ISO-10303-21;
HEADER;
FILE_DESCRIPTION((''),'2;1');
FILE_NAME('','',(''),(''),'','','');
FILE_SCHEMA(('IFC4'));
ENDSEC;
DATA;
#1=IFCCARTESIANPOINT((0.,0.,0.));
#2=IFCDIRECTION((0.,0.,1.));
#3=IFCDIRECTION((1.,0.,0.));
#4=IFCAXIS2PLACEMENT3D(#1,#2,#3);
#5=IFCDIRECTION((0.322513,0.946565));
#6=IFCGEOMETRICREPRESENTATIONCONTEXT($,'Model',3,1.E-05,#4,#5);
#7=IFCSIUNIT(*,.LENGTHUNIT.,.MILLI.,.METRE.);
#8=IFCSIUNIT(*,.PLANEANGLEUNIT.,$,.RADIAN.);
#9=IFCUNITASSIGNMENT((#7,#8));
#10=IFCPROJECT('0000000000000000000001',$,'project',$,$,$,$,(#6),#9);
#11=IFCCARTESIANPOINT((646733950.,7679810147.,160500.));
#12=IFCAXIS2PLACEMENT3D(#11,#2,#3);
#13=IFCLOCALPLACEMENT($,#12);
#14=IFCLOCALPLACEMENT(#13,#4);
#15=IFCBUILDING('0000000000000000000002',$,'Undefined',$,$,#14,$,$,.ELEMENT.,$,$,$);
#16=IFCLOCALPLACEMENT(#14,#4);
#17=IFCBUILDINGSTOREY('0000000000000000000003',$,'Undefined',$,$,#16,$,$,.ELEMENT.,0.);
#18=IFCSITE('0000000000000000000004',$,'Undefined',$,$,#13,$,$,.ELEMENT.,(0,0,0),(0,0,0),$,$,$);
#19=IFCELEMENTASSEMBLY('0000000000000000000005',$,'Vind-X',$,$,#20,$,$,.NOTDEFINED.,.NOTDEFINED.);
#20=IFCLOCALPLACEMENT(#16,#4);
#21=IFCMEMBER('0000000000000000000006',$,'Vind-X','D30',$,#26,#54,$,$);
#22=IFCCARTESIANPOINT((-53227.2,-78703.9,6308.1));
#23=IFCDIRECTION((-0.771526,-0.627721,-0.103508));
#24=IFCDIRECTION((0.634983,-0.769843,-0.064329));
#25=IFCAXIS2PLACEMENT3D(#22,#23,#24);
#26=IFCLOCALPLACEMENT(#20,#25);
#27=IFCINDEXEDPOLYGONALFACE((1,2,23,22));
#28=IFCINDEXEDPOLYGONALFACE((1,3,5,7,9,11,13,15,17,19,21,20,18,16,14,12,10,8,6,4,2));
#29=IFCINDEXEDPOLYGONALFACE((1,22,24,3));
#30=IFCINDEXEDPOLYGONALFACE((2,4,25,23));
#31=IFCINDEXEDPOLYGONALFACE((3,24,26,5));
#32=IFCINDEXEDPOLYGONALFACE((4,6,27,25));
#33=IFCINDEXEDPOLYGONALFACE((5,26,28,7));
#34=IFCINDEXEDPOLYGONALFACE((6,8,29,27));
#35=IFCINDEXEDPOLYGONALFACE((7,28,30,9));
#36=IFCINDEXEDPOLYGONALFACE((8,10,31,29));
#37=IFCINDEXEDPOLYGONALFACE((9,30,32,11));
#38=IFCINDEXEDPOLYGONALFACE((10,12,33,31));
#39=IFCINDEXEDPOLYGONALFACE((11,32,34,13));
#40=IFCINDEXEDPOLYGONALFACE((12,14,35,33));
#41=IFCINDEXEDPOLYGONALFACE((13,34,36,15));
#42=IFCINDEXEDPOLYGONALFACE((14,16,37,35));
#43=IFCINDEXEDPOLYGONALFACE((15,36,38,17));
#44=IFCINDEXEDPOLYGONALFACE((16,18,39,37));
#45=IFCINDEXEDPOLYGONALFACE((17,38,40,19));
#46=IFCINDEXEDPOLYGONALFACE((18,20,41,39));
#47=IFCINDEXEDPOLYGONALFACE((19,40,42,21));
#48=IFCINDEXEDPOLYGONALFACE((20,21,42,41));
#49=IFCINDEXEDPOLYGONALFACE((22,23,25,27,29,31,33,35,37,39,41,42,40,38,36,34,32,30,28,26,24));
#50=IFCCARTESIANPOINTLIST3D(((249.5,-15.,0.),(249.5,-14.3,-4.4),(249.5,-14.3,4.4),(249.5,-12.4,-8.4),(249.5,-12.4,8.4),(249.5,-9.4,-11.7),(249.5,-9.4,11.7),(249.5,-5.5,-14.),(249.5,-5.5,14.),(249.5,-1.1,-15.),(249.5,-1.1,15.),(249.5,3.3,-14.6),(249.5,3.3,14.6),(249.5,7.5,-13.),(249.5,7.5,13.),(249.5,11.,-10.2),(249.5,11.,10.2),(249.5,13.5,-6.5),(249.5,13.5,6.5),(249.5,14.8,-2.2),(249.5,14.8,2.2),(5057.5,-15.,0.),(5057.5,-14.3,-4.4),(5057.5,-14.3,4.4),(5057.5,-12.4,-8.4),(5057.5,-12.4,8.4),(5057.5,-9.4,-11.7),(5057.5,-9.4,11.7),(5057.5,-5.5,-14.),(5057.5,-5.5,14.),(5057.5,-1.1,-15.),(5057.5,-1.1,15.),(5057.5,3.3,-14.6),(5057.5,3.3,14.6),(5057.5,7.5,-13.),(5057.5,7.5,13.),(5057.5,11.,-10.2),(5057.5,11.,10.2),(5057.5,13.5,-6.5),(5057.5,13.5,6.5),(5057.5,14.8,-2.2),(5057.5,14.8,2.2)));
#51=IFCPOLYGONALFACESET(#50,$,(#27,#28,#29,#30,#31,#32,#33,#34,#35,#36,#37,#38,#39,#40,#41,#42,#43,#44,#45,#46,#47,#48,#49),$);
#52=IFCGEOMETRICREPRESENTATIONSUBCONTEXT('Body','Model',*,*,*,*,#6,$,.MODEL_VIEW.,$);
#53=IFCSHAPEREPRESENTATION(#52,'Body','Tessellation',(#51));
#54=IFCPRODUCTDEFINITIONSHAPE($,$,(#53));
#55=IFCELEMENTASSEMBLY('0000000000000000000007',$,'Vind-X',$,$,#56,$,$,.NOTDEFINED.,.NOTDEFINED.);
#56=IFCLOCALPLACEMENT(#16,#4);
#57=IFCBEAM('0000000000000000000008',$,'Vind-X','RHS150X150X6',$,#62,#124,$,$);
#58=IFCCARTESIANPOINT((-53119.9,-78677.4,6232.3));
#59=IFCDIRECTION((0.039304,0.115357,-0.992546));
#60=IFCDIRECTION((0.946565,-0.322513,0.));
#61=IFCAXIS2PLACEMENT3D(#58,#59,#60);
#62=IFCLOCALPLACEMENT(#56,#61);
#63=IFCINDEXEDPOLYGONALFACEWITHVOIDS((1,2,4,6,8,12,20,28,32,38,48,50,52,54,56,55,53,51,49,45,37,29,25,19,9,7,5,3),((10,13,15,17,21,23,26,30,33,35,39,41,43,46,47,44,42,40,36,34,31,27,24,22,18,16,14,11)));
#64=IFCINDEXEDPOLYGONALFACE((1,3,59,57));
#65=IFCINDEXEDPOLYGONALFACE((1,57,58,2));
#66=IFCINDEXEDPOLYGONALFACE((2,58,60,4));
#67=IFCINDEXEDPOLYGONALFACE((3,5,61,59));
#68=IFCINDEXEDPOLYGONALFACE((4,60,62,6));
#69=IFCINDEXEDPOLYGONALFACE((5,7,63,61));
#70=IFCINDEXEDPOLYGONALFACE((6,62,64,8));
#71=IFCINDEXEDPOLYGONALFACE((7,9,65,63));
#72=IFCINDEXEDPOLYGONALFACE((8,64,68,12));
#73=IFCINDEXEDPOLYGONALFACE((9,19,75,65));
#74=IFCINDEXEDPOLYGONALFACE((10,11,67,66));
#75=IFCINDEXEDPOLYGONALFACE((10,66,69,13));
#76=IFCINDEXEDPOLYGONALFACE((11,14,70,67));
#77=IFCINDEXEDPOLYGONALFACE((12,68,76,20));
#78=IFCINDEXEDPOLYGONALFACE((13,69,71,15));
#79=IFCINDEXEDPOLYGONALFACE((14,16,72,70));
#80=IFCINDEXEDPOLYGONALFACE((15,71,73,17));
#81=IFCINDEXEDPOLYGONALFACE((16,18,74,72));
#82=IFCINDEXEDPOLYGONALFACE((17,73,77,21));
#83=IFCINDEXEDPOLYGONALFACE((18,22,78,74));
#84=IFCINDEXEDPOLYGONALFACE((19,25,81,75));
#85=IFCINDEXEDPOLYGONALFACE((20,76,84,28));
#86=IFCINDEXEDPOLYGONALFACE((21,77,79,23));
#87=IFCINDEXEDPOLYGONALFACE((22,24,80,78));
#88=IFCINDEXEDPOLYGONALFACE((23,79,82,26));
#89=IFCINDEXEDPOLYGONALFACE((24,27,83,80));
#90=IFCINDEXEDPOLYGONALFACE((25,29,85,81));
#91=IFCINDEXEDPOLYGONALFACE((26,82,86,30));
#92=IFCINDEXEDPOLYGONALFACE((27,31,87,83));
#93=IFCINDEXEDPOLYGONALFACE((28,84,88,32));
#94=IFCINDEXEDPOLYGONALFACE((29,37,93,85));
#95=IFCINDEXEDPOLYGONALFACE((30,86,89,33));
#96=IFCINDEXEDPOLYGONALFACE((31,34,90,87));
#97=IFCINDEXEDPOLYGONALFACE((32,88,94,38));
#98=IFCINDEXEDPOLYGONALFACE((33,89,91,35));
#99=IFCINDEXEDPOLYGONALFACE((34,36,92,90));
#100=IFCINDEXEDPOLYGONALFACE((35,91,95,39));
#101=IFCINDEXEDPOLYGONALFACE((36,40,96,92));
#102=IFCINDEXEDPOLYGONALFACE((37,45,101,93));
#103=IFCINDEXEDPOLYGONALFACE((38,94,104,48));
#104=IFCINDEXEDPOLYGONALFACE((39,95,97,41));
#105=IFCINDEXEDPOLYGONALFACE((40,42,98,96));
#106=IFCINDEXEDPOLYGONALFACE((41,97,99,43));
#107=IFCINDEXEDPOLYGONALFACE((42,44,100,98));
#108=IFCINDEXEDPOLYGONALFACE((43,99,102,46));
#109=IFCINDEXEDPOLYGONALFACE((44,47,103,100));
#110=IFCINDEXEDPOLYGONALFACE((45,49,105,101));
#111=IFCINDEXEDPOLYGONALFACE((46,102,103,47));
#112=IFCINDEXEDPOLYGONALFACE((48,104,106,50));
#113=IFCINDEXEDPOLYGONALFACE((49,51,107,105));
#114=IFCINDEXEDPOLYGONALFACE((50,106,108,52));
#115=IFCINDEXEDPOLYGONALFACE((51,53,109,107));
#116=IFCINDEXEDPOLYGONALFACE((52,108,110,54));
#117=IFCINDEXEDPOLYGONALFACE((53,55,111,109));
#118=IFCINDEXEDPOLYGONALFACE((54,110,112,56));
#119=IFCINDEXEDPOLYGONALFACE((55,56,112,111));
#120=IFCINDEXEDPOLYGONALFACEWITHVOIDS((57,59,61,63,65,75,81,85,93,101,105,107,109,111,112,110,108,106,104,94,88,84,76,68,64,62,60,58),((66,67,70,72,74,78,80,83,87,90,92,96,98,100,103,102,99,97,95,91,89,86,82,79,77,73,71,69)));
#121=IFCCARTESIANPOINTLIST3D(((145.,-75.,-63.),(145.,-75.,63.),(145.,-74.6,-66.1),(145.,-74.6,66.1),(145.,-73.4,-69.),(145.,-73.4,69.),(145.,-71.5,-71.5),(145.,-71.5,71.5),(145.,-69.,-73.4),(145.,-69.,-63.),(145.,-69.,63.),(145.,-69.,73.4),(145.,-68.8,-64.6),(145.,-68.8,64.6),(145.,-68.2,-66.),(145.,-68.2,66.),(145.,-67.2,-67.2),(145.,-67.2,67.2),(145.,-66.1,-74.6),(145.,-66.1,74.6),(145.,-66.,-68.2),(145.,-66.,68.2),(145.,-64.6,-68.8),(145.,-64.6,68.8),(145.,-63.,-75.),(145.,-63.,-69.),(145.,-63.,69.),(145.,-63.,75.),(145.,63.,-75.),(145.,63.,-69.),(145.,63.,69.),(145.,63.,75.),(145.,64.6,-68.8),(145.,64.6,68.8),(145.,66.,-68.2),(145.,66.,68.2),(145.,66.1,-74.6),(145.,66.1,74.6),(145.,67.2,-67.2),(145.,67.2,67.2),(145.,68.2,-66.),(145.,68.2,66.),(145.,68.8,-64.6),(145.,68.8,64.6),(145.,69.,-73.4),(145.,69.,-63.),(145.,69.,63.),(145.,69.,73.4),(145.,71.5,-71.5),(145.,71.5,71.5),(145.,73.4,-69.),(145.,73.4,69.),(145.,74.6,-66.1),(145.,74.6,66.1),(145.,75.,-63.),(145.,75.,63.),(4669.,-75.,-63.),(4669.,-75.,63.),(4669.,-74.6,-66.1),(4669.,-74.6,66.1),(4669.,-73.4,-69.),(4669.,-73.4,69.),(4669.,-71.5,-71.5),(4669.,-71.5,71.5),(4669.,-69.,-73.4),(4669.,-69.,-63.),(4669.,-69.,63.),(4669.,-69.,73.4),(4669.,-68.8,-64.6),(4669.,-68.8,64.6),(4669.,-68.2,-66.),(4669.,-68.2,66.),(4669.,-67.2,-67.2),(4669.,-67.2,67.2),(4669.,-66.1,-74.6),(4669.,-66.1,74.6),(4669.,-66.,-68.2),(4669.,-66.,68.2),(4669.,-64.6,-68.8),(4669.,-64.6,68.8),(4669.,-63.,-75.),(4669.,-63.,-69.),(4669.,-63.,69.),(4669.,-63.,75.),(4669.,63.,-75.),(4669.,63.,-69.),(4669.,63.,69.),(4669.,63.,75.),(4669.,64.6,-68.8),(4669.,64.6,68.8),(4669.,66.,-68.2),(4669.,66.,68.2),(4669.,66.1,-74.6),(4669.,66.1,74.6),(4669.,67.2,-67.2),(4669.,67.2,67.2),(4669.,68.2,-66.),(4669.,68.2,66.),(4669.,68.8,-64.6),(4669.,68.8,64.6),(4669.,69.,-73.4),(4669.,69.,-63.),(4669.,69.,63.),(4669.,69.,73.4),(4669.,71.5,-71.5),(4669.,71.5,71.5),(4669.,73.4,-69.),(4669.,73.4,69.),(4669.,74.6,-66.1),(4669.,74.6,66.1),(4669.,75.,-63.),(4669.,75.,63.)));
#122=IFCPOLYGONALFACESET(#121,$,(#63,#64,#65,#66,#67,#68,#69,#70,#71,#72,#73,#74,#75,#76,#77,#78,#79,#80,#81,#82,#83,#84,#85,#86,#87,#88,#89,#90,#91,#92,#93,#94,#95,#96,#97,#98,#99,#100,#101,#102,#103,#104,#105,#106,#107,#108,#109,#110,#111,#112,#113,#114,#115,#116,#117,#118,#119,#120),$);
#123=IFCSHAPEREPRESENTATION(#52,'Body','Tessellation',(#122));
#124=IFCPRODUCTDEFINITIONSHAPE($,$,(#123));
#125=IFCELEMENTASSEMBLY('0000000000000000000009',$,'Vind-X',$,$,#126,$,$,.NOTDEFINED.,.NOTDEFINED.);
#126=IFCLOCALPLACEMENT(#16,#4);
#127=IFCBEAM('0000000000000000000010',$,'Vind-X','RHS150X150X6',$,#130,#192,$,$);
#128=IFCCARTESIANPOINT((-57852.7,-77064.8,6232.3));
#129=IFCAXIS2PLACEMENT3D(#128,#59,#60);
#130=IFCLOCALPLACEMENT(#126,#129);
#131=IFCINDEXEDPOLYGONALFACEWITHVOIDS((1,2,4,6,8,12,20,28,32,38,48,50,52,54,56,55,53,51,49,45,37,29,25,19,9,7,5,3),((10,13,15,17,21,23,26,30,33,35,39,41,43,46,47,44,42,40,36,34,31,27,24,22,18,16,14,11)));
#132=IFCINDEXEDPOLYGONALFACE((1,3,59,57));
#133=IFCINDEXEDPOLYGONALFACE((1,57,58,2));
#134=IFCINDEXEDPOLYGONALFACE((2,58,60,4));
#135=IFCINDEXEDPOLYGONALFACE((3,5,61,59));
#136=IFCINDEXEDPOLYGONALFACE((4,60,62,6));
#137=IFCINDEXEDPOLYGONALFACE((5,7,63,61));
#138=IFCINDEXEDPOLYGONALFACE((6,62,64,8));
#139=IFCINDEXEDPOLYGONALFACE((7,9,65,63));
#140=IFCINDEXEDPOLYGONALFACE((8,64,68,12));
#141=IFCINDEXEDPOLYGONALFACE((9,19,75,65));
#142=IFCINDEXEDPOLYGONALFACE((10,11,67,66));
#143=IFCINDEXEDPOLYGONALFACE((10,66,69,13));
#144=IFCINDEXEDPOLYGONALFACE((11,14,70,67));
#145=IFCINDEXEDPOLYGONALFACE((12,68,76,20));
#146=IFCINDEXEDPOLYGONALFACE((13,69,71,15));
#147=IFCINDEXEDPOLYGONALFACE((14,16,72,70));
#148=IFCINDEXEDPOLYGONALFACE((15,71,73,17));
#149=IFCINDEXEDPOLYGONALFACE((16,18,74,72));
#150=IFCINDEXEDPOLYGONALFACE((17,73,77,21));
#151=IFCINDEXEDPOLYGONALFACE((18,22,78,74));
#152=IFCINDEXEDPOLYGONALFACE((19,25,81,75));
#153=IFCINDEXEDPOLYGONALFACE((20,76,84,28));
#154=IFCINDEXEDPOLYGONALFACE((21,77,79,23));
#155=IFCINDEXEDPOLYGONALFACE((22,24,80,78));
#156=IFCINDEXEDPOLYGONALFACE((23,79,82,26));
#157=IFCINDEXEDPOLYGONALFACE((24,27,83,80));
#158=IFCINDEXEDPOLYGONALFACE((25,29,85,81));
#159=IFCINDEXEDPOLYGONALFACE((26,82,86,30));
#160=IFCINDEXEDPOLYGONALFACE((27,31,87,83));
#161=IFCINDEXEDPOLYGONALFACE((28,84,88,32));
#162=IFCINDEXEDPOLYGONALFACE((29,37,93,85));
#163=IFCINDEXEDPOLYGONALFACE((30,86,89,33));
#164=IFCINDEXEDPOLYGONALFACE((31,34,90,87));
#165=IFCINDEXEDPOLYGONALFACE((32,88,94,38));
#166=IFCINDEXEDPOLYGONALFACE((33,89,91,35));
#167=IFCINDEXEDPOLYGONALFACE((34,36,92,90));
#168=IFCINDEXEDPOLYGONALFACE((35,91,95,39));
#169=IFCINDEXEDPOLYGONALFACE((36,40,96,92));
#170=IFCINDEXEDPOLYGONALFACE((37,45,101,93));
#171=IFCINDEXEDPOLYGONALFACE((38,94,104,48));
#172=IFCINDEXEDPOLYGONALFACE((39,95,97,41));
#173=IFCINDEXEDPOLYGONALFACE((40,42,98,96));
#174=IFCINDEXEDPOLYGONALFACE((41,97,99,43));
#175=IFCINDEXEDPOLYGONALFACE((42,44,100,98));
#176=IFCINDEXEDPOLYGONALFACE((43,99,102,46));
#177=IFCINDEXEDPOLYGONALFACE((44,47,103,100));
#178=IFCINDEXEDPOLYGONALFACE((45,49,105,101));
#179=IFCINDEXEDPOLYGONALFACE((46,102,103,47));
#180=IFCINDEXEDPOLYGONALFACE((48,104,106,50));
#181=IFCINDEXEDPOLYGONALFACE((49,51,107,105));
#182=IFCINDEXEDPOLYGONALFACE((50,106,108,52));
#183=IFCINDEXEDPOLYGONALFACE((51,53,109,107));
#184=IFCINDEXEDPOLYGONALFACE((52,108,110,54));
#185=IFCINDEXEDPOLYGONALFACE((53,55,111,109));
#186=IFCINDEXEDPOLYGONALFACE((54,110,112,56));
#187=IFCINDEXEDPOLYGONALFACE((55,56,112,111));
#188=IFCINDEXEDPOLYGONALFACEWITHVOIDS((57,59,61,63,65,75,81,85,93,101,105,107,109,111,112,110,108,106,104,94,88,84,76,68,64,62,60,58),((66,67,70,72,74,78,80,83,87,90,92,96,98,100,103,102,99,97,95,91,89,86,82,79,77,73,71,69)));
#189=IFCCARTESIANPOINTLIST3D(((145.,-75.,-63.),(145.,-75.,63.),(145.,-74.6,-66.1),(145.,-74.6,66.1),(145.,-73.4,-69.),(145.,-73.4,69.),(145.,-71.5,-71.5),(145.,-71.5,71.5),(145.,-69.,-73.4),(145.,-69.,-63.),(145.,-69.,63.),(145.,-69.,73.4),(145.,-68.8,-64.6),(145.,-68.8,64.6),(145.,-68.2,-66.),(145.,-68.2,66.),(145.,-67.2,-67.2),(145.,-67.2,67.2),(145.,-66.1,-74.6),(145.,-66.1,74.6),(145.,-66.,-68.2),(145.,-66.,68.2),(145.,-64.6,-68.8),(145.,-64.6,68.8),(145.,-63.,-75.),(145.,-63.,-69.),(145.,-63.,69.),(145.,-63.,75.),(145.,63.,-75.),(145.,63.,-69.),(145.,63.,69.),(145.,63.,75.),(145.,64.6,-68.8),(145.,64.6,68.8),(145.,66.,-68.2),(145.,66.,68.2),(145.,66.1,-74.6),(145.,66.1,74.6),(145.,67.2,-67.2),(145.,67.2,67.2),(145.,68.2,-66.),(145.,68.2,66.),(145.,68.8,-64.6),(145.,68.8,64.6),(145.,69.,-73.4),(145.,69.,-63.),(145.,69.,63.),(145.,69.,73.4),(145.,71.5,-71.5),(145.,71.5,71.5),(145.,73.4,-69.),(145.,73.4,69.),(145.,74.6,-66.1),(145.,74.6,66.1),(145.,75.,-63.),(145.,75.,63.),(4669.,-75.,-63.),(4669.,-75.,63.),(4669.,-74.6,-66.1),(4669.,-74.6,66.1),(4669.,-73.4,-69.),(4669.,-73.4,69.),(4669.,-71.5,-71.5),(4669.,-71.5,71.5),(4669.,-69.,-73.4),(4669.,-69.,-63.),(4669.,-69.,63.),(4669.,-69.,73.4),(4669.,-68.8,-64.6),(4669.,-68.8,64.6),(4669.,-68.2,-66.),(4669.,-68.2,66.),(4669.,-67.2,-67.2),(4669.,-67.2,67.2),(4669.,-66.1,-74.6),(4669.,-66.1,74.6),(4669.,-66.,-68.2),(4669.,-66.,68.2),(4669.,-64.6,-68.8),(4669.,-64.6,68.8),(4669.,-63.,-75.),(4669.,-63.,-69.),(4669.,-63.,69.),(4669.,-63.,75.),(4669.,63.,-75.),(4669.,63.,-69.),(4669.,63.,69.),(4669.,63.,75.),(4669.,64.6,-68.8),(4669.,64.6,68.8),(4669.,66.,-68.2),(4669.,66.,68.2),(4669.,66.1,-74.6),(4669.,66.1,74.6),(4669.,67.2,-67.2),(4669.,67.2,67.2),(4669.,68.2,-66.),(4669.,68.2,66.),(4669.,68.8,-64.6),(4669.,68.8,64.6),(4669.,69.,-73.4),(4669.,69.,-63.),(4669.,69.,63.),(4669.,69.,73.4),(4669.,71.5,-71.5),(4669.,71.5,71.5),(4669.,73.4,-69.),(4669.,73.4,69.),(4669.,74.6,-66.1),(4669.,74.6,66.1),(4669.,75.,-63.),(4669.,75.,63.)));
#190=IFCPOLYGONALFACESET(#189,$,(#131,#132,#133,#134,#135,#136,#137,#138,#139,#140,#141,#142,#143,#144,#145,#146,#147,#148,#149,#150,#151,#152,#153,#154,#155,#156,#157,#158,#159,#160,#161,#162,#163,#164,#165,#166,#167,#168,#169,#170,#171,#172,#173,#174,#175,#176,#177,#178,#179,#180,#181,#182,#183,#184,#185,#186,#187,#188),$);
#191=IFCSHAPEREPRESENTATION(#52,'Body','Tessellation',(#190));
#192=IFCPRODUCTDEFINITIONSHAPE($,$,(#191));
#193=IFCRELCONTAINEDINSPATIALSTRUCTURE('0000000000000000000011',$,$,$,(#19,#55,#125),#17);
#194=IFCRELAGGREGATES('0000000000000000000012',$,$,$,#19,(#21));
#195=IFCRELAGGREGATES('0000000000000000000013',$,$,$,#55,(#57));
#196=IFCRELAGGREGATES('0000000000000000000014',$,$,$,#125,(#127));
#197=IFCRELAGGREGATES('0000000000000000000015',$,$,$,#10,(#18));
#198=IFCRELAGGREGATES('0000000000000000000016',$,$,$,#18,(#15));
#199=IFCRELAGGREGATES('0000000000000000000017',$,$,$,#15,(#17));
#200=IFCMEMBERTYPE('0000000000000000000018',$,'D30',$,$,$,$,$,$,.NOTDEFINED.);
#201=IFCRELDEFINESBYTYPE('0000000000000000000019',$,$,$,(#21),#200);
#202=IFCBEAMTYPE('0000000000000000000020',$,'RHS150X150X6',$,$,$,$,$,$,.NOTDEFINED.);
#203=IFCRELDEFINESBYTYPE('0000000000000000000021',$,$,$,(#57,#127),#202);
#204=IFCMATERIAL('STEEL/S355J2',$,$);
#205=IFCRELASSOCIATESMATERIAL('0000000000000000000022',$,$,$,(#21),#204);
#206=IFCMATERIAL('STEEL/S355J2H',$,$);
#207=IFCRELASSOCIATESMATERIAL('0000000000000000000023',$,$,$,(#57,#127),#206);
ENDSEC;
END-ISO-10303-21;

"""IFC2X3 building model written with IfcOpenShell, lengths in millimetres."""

from ifc_helpers import new_model, si_unit, direction, frame, origin_with_axes, origin_2d_with_axis, place, context, subcontext, project, spatial, hollow_rectangle, circle, extrude, clip, halfspace, material, type_object, element, aggregate, save


model = new_model("IFC2X3")

# Units and contexts
model_context = context("Model", 3, precision=1e-05, world=origin_with_axes(), true_north=direction((0.322513, 0.946565)))
body_context = subcontext(model_context, "Body", "Model", "MODEL_VIEW")
ifc_project = project(units=[si_unit("LENGTHUNIT", "METRE", prefix="MILLI"), si_unit("PLANEANGLEUNIT", "RADIAN")], contexts=[model_context])

# Site, building, storey
site_placement = place(None, frame((646733950.0, 7679810147.0, 160500.0), z_axis=(0.0, 0.0, 1.0), x_axis=(1.0, 0.0, 0.0)))
site = spatial("IfcSite", under=ifc_project, at=site_placement, Name="Undefined", CompositionType="ELEMENT", RefLatitude=(0, 0, 0), RefLongitude=(0, 0, 0))
building_placement = place(site_placement, origin_with_axes())
building = spatial("IfcBuilding", under=site, at=building_placement, Name="Undefined", CompositionType="ELEMENT")
storey_placement = place(building_placement, origin_with_axes())
storey = spatial("IfcBuildingStorey", under=building, at=storey_placement, Name="Undefined", CompositionType="ELEMENT", Elevation=0.0)

# Element assembly, member
assembly_1_placement = place(storey_placement, origin_with_axes())
assembly_1 = element("IfcElementAssembly", 1, at=assembly_1_placement, inside=storey, Name="Vind-X", AssemblyPlace="NOTDEFINED", PredefinedType="NOTDEFINED")
ifc_material_1 = material(Name="STEEL/S355J2")
member_type = type_object("IfcMemberType", Name="D30", PredefinedType="NOTDEFINED")
member_placement = place(assembly_1_placement, frame((-53227.2, -78703.9, 6308.1), z_axis=(-0.771526, -0.627721, -0.103508), x_axis=(0.634983, -0.769843, -0.064329)))
member = element("IfcMember", 2, at=member_placement, type_object=member_type, material=ifc_material_1, Name="Vind-X", Description="D30", context=body_context, shape_type="Clipping", body=[
    clip(extrude(circle(Radius=15.0, at=origin_2d_with_axis()), frame((5057.5, 0.0, 0.0), z_axis=(-1.0, 0.0, 0.0), x_axis=(0.0, -1.0, 0.0)), (0.0, 0.0, 1.0), 5057.5), halfspace(frame((249.5, -22.5, 0.0), z_axis=(1.0, 0.0, 0.0), x_axis=(0.0, 0.0, 1.0)), True)),
])

# Element assemblies, beams
assembly_2_placement = place(storey_placement, origin_with_axes())
assembly_2 = element("IfcElementAssembly", 3, at=assembly_2_placement, inside=storey, Name="Vind-X", AssemblyPlace="NOTDEFINED", PredefinedType="NOTDEFINED")
ifc_material_2 = material(Name="STEEL/S355J2H")
beam_type = type_object("IfcBeamType", Name="RHS150X150X6", PredefinedType="NOTDEFINED")
beam_1_placement = place(assembly_2_placement, frame((-53119.9, -78677.4, 6232.3), z_axis=(0.039304, 0.115357, -0.992546), x_axis=(0.946565, -0.322513, 0.0)))
beam_1 = element("IfcBeam", 4, at=beam_1_placement, type_object=beam_type, material=ifc_material_2, Name="Vind-X", Description="RHS150X150X6", context=body_context, shape_type="Clipping", body=[
    clip(clip(extrude(hollow_rectangle(XDim=150.0, YDim=150.0, WallThickness=6.0, InnerFilletRadius=6.0, OuterFilletRadius=12.0, at=origin_2d_with_axis()), frame((4814.0, 0.0, 0.0), z_axis=(-1.0, 0.0, 0.0), x_axis=(0.0, -1.0, 0.0)), (0.0, 0.0, 1.0), 4814.0), halfspace(frame((4669.0, 0.0, 0.0), z_axis=(-1.0, 0.0, 0.0), x_axis=(0.0, 1.0, 0.0)), True)), halfspace(frame((145.0, 0.0, 0.0), z_axis=(1.0, 0.0, 0.0), x_axis=(0.0, -1.0, 0.0)), True)),
])
assembly_3_placement = place(storey_placement, origin_with_axes())
assembly_3 = element("IfcElementAssembly", 5, at=assembly_3_placement, inside=storey, Name="Vind-X", AssemblyPlace="NOTDEFINED", PredefinedType="NOTDEFINED")
beam_2_placement = place(assembly_3_placement, frame((-57852.7, -77064.8, 6232.3), z_axis=(0.039304, 0.115357, -0.992546), x_axis=(0.946565, -0.322513, 0.0)))
beam_2 = element("IfcBeam", 6, at=beam_2_placement, type_object=beam_type, material=ifc_material_2, Name="Vind-X", Description="RHS150X150X6", context=body_context, shape_type="Clipping", body=[
    clip(clip(extrude(hollow_rectangle(XDim=150.0, YDim=150.0, WallThickness=6.0, InnerFilletRadius=6.0, OuterFilletRadius=12.0, at=origin_2d_with_axis()), frame((4814.0, 0.0, 0.0), z_axis=(-1.0, 0.0, 0.0), x_axis=(0.0, -1.0, 0.0)), (0.0, 0.0, 1.0), 4814.0), halfspace(frame((4669.0, 0.0, 0.0), z_axis=(-1.0, 0.0, 0.0), x_axis=(0.0, 1.0, 0.0)), True)), halfspace(frame((145.0, 0.0, 0.0), z_axis=(1.0, 0.0, 0.0), x_axis=(0.0, -1.0, 0.0)), True)),
])

aggregate(assembly_1, [member])

aggregate(assembly_2, [beam_1])
aggregate(assembly_3, [beam_2])

save(model, "model.ifc")
